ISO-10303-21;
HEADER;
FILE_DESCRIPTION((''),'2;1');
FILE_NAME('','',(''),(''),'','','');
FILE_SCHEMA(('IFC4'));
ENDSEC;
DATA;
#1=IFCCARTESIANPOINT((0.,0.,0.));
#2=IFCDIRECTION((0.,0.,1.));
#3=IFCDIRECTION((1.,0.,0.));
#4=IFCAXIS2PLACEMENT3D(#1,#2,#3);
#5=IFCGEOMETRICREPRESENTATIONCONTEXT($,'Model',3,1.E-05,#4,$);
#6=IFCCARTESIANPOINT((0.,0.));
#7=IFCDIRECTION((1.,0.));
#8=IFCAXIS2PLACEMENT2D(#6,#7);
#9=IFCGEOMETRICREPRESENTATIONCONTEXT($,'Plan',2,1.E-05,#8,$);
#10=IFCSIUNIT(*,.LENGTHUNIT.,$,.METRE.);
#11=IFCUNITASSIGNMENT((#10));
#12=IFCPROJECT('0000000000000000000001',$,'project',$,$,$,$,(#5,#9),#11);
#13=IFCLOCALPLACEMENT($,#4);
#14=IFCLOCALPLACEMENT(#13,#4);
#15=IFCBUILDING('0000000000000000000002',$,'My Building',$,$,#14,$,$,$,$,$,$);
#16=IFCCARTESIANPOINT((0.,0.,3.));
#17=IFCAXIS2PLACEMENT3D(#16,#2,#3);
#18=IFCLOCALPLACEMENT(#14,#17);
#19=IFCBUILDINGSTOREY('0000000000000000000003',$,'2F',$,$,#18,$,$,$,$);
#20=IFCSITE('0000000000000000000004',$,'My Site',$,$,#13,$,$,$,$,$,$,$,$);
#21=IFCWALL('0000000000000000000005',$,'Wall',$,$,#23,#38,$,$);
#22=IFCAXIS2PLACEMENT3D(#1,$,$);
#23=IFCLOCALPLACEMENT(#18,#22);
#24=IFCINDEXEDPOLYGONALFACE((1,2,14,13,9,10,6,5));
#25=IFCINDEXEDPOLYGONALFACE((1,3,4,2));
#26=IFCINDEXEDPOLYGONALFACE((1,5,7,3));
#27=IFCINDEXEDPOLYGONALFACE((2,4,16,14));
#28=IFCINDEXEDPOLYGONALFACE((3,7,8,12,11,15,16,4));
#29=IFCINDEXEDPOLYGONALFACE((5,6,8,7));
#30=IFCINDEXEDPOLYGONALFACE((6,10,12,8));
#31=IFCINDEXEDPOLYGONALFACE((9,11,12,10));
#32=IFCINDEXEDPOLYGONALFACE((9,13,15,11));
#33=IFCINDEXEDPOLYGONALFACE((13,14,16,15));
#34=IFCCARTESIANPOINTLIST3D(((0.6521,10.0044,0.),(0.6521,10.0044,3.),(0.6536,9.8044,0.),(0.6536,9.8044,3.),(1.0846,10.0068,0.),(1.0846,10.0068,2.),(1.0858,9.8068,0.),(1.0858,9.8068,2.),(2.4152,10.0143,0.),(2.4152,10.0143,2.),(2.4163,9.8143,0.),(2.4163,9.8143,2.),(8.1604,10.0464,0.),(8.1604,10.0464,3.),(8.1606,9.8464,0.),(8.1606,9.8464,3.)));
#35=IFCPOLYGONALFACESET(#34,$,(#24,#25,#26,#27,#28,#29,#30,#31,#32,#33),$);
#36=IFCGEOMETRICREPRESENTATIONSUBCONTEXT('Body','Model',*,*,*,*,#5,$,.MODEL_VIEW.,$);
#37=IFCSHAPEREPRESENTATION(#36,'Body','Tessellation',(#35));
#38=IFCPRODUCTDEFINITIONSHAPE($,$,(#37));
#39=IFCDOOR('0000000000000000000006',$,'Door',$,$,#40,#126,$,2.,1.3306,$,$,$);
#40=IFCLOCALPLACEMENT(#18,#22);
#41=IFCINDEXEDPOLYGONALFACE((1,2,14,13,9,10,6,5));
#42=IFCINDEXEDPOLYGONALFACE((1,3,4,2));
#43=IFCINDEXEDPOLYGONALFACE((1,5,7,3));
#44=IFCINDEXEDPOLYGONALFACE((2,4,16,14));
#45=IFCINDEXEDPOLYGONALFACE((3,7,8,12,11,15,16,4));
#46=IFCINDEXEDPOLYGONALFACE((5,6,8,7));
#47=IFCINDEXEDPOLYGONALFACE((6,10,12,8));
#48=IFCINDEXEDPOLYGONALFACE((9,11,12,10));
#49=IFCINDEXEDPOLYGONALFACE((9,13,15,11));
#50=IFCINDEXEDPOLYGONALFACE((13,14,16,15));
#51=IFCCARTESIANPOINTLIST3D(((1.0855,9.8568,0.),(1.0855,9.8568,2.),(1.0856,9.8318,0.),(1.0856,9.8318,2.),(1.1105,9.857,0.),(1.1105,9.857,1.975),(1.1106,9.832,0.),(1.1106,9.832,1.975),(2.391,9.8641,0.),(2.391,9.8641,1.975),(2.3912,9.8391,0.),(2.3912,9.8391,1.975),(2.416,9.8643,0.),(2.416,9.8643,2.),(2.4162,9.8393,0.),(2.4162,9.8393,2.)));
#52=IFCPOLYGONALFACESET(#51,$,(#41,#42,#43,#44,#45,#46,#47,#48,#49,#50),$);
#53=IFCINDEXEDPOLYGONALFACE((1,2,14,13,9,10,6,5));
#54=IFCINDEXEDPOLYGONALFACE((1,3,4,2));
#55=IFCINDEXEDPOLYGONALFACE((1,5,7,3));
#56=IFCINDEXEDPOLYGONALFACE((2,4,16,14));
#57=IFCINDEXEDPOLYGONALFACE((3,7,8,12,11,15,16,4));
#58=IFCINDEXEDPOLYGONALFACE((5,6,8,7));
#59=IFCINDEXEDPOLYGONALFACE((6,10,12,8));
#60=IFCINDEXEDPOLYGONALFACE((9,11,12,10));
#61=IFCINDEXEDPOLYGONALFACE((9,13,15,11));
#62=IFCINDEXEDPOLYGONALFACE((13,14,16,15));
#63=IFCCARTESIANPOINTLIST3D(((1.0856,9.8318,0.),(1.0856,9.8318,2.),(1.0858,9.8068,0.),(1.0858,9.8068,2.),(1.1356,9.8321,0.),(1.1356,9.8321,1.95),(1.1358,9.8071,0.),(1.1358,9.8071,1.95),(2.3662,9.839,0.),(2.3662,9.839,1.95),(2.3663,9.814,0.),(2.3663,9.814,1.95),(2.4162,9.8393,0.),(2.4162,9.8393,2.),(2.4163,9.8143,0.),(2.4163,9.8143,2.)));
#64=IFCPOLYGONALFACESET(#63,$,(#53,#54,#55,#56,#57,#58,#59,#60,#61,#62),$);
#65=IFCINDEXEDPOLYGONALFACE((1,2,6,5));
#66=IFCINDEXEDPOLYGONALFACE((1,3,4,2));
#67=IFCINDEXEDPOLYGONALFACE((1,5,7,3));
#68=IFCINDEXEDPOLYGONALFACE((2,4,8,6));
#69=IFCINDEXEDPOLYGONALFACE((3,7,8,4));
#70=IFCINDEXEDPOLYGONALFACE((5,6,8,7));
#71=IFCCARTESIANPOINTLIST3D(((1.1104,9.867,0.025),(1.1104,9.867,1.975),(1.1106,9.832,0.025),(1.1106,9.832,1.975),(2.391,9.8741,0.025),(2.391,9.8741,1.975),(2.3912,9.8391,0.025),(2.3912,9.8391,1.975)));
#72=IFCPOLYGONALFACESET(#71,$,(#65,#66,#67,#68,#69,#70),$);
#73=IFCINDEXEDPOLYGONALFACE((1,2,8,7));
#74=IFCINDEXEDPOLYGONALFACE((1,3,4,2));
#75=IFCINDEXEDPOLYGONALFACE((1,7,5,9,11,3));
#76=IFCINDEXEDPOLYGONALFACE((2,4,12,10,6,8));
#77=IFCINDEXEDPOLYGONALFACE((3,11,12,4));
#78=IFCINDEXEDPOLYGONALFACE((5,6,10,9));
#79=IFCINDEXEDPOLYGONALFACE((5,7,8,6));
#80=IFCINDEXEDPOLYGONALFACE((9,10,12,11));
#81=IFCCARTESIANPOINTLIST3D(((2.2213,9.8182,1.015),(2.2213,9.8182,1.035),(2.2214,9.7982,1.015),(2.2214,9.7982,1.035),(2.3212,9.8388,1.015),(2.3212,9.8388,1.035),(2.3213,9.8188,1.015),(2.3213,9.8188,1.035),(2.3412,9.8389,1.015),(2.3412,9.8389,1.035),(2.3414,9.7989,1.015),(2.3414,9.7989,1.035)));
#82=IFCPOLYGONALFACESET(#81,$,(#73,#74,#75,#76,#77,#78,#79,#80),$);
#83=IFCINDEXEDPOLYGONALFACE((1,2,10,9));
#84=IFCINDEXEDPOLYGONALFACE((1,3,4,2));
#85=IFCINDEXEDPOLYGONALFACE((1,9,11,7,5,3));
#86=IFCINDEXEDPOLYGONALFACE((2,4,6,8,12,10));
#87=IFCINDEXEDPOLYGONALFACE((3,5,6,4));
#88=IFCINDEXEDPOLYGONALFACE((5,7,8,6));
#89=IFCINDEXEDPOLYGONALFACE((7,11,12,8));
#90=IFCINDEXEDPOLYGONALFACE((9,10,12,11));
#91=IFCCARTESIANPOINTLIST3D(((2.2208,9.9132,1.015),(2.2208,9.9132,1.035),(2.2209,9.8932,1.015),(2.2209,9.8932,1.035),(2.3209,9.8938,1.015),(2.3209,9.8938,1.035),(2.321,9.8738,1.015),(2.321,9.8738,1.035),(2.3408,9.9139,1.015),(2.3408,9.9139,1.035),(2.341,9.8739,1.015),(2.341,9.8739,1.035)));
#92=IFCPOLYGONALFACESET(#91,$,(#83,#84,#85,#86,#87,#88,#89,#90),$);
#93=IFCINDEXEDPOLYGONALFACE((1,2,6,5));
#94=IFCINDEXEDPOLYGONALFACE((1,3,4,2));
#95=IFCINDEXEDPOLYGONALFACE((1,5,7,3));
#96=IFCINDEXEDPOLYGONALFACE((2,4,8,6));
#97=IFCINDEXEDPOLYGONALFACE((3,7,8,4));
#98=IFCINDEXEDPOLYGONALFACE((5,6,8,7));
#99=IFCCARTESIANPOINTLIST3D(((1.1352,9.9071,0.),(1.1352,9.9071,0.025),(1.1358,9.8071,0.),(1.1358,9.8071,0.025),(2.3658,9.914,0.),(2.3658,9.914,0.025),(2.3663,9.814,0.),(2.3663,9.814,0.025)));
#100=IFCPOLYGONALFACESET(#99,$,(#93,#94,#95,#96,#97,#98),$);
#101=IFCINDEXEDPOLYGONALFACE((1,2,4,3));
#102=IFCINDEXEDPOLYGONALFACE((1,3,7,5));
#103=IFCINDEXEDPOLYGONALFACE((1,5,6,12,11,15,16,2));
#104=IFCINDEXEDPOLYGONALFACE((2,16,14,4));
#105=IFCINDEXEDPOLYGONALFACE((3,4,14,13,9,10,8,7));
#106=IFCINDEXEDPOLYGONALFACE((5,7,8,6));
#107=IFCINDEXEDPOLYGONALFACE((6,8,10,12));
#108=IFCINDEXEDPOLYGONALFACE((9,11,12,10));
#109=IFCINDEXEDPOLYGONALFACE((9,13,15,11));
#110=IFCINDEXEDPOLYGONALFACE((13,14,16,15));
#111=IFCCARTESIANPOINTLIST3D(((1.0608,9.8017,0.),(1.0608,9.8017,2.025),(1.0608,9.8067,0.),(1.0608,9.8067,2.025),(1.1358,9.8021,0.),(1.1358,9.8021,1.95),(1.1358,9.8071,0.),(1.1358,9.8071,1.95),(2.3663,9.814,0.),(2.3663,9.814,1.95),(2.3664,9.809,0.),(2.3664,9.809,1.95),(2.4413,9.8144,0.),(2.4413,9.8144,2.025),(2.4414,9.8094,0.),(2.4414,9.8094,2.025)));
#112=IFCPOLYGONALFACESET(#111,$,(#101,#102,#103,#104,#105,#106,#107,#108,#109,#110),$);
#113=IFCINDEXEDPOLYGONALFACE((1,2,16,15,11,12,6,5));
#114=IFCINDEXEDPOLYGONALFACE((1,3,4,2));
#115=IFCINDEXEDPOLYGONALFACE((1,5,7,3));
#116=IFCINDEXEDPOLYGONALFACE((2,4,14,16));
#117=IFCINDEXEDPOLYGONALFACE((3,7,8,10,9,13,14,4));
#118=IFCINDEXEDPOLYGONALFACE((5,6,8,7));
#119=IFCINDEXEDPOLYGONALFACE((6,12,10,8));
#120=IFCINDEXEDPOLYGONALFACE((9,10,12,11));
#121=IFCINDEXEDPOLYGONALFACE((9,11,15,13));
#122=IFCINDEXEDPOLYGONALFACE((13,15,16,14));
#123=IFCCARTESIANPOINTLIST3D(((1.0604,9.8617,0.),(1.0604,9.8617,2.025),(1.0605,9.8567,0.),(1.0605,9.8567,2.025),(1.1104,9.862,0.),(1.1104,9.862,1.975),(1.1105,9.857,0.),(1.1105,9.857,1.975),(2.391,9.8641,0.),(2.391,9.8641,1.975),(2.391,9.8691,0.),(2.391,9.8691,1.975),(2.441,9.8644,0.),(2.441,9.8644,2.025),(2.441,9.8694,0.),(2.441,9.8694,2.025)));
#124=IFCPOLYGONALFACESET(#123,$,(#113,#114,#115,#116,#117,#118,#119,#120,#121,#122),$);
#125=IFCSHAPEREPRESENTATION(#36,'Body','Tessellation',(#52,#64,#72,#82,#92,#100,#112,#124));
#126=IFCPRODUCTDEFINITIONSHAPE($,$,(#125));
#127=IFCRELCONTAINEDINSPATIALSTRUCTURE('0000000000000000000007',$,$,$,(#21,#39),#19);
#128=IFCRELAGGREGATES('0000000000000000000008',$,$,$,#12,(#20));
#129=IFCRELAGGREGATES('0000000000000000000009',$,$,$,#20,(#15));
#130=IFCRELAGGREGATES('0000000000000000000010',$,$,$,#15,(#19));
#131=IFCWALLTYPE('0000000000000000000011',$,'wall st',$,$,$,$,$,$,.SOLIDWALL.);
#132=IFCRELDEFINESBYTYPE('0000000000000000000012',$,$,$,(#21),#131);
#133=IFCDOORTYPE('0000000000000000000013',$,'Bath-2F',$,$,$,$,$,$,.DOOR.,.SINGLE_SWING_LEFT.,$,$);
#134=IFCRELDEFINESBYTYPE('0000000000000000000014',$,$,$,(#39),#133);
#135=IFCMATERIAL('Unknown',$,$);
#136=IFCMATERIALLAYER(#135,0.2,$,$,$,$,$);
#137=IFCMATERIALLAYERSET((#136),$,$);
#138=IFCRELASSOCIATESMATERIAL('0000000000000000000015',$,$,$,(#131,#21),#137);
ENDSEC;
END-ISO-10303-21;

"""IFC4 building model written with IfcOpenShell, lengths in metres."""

from ifc_helpers import new_model, entity, si_unit, frame, origin_with_axes, origin_2d_with_axis, place, context, subcontext, project, spatial, line, indexed_curve, outline, extrude, shape, source, transform, mapped, material, layer, layer_set, layer_usage, type_object, type_shapes, element, fill, save


model = new_model("IFC4")

# Units and contexts
model_context = context("Model", 3, precision=1e-05, world=origin_with_axes())
plan_context = context("Plan", 2, precision=1e-05, world=origin_2d_with_axis())
body_context_1 = subcontext(model_context, "Body", "Model", "MODEL_VIEW")
body_context_2 = subcontext(plan_context, "Body", "Plan", "PLAN_VIEW")
ifc_project = project(units=[si_unit("LENGTHUNIT", "METRE")], contexts=[model_context, plan_context])

# Site, building, storey
site_placement = place(None, origin_with_axes())
site = spatial("IfcSite", under=ifc_project, at=site_placement, Name="My Site")
building_placement = place(site_placement, origin_with_axes())
building = spatial("IfcBuilding", under=site, at=building_placement, Name="My Building")
storey_placement = place(building_placement, frame((0.0, 0.0, 3.0), z_axis=(0.0, 0.0, 1.0), x_axis=(1.0, 0.0, 0.0)))
storey = spatial("IfcBuildingStorey", under=building, at=storey_placement, Name="2F")

# Shared definitions
ifc_material = material(Name="Unknown")

# Shared definitions
ifc_layer_1 = layer(ifc_material, 0.2)
ifc_layer_set_1 = layer_set([ifc_layer_1])
wall_type_1 = type_object("IfcWallType", Name="wall st", PredefinedType="SOLIDWALL", material=ifc_layer_set_1)

# Wall, opening, door
ifc_layer_usage_1 = layer_usage(ifc_layer_set_1, "AXIS2", "POSITIVE", 0.0)
wall_1_placement = place(storey_placement, frame((0.4536, 9.8033, 0.0), z_axis=(0.0, 0.0, 1.0), x_axis=(0.999984, 0.00559, 0.0)))
wall_1 = element("IfcWall", 1, at=wall_1_placement, inside=storey, type_object=wall_type_1, material=ifc_layer_usage_1, Name="Wall", context=body_context_1, shape_type="SweptSolid", body=[
    extrude(outline(indexed_curve([(0.2, 0.0), (0.1997, 0.2), (7.708, 0.2), (7.7071, 0.0)], segments=[line(1, 2, 3, 4, 1)])), origin_with_axes(), (0.0, 0.0, 1.0), 3.0),
])
shared_shape_1 = source(origin_with_axes(), body_context_1, "Body", "SweptSolid", [
    extrude(outline(indexed_curve([(0.0, 0.0), (1.3306, 0.0), (1.3306, 2.0), (0.0, 2.0)], segments=[line(1, 2, 3, 4, 1)])), frame((0.0, -0.6, 0.0), z_axis=(0.0, -1.0, 0.0), x_axis=(1.0, 0.0, 0.0)), (0.0, 0.0, -1.0), 1.2),
])
opening_1_placement = place(wall_1_placement, frame((0.6322, 0.0, 0.0), z_axis=(0.0, 0.0, 1.0), x_axis=(1.0, 0.0, 0.0)))
opening_1 = element("IfcOpeningElement", 2, at=opening_1_placement, cuts=wall_1, PredefinedType="OPENING", context=body_context_1, shape_type="MappedRepresentation", body=[
    mapped(shared_shape_1, transform((0.0, 0.0, 0.0), x_axis=(1.0, 0.0, 0.0), y_axis=(0.0, 1.0, 0.0), z_axis=(0.0, 0.0, 1.0), scale=1.0)),
])
door_type_1 = type_object("IfcDoorType", Name="Bath-2F", OperationType="SINGLE_SWING_LEFT", PredefinedType="DOOR")
shared_shape_2 = source(origin_with_axes(), body_context_1, "Body", "SweptSolid", [
    extrude(outline(indexed_curve([(0.0, 0.0), (0.0, 2.0), (1.3306, 2.0), (1.3306, 0.0), (1.3056, 0.0), (1.3056, 1.975), (0.025, 1.975), (0.025, 0.0)], segments=[line(1, 2, 3, 4, 5, 6, 7, 8, 1)])), frame((0.0, 0.025, 0.0), z_axis=(0.0, -1.0, 0.0), x_axis=(1.0, 0.0, 0.0)), (0.0, 0.0, -1.0), 0.025),
    extrude(outline(indexed_curve([(0.0, 0.0), (0.0, 2.0), (1.3306, 2.0), (1.3306, 0.0), (1.2806, 0.0), (1.2806, 1.95), (0.05, 1.95), (0.05, 0.0)], segments=[line(1, 2, 3, 4, 5, 6, 7, 8, 1)])), frame((0.0, 0.0, 0.0), z_axis=(0.0, -1.0, 0.0), x_axis=(1.0, 0.0, 0.0)), (0.0, 0.0, -1.0), 0.025),
    extrude(outline(indexed_curve([(0.0, 0.0), (1.2806, 0.0), (1.2806, 0.035), (0.0, 0.035)], segments=[line(1, 2, 3, 4, 1)])), frame((0.025, 0.025, 0.025), z_axis=(0.0, 0.0, 1.0), x_axis=(1.0, 0.0, 0.0)), (0.0, 0.0, 1.0), 1.95),
    extrude(outline(indexed_curve([(0.0, 0.0), (0.0, -0.04), (-0.12, -0.04), (-0.12, -0.02), (-0.02, -0.02), (-0.02, 0.0)], segments=[line(1, 2, 3, 4, 5, 6, 1)])), frame((1.2556, 0.025, 1.015), z_axis=(0.0, 0.0, 1.0), x_axis=(1.0, 0.0, 0.0)), (0.0, 0.0, 1.0), 0.02),
    extrude(outline(indexed_curve([(0.0, 0.0), (0.0, 0.04), (-0.12, 0.04), (-0.12, 0.02), (-0.02, 0.02), (-0.02, 0.0)], segments=[line(1, 2, 3, 4, 5, 6, 1)])), frame((1.2556, 0.06, 1.015), z_axis=(0.0, 0.0, 1.0), x_axis=(1.0, 0.0, 0.0)), (0.0, 0.0, 1.0), 0.02),
    extrude(outline(indexed_curve([(0.0, 0.0), (1.2306, 0.0), (1.2306, 0.1), (0.0, 0.1)], segments=[line(1, 2, 3, 4, 1)])), frame((0.05, 0.0, 0.0), z_axis=(0.0, 0.0, 1.0), x_axis=(1.0, 0.0, 0.0)), (0.0, 0.0, 1.0), 0.025),
    extrude(outline(indexed_curve([(0.0, 0.0), (0.0, 2.025), (1.3806, 2.025), (1.3806, 0.0), (1.3056, 0.0), (1.3056, 1.95), (0.075, 1.95), (0.075, 0.0)], segments=[line(1, 2, 3, 4, 5, 6, 7, 8, 1)])), frame((-0.025, -0.005, 0.0), z_axis=(0.0, -1.0, 0.0), x_axis=(1.0, 0.0, 0.0)), (0.0, 0.0, -1.0), 0.005),
    extrude(outline(indexed_curve([(0.0, 0.0), (0.0, 2.025), (1.3806, 2.025), (1.3806, 0.0), (1.3306, 0.0), (1.3306, 1.975), (0.05, 1.975), (0.05, 0.0)], segments=[line(1, 2, 3, 4, 5, 6, 7, 8, 1)])), frame((-0.025, 0.05, 0.0), z_axis=(0.0, -1.0, 0.0), x_axis=(1.0, 0.0, 0.0)), (0.0, 0.0, -1.0), 0.005),
])
shared_shape_3 = source(origin_with_axes(), body_context_2, "Body", "Curve2D", [
    entity("IfcIndexedPolyCurve", entity("IfcCartesianPointList2D", [[0.0, 0.0], [0.0, 0.05], [0.025, 0.05], [0.025, 0.025], [0.05, 0.025], [0.05, 0.0]]), [entity("IfcLineIndex", [1, 2, 3, 4, 5, 6, 1])]),
    entity("IfcIndexedPolyCurve", entity("IfcCartesianPointList2D", [[1.3306, 0.0], [1.3306, 0.05], [1.3056, 0.05], [1.3056, 0.025], [1.2806, 0.025], [1.2806, 0.0]]), [entity("IfcLineIndex", [1, 2, 3, 4, 5, 6, 1])]),
    entity("IfcTrimmedCurve", entity("IfcEllipse", entity("IfcAxis2Placement2D", entity("IfcCartesianPoint", [0.06, 0.05]), entity("IfcDirection", [1.0, 0.0])), 1.2456, 1.2806), [entity("IfcCartesianPoint", [1.3056, 0.05])], [entity("IfcCartesianPoint", [0.06, 1.3306])], True, "CARTESIAN"),
    entity("IfcIndexedPolyCurve", entity("IfcCartesianPointList2D", [[0.025, 0.05], [0.06, 0.05], [0.06, 1.3306], [0.025, 1.3306]]), [entity("IfcLineIndex", [1, 2, 3, 4, 1])]),
])
type_shapes(door_type_1, [shared_shape_2, shared_shape_3])
door_1_placement = place(opening_1_placement, frame((0.0, 0.0, 0.0), z_axis=(0.0, 0.0, 1.0), x_axis=(1.0, 0.0, 0.0)))
door_1 = element("IfcDoor", 3, at=door_1_placement, inside=storey, type_object=door_type_1, Name="Door", OverallHeight=2.0, OverallWidth=1.3306, shapes=[
    shape(body_context_1, "Body", "MappedRepresentation", [mapped(shared_shape_2, transform((0.0, 0.0, 0.0), x_axis=(1.0, 0.0, 0.0), y_axis=(0.0, 1.0, 0.0), z_axis=(0.0, 0.0, 1.0), scale=1.0))]),
    shape(body_context_2, "Body", "MappedRepresentation", [mapped(shared_shape_3, transform((0.0, 0.0, 0.0), x_axis=(1.0, 0.0, 0.0), y_axis=(0.0, 1.0, 0.0), z_axis=(0.0, 0.0, 1.0), scale=1.0))]),
])
fill(opening_1, door_1)

save(model, "model.ifc")
